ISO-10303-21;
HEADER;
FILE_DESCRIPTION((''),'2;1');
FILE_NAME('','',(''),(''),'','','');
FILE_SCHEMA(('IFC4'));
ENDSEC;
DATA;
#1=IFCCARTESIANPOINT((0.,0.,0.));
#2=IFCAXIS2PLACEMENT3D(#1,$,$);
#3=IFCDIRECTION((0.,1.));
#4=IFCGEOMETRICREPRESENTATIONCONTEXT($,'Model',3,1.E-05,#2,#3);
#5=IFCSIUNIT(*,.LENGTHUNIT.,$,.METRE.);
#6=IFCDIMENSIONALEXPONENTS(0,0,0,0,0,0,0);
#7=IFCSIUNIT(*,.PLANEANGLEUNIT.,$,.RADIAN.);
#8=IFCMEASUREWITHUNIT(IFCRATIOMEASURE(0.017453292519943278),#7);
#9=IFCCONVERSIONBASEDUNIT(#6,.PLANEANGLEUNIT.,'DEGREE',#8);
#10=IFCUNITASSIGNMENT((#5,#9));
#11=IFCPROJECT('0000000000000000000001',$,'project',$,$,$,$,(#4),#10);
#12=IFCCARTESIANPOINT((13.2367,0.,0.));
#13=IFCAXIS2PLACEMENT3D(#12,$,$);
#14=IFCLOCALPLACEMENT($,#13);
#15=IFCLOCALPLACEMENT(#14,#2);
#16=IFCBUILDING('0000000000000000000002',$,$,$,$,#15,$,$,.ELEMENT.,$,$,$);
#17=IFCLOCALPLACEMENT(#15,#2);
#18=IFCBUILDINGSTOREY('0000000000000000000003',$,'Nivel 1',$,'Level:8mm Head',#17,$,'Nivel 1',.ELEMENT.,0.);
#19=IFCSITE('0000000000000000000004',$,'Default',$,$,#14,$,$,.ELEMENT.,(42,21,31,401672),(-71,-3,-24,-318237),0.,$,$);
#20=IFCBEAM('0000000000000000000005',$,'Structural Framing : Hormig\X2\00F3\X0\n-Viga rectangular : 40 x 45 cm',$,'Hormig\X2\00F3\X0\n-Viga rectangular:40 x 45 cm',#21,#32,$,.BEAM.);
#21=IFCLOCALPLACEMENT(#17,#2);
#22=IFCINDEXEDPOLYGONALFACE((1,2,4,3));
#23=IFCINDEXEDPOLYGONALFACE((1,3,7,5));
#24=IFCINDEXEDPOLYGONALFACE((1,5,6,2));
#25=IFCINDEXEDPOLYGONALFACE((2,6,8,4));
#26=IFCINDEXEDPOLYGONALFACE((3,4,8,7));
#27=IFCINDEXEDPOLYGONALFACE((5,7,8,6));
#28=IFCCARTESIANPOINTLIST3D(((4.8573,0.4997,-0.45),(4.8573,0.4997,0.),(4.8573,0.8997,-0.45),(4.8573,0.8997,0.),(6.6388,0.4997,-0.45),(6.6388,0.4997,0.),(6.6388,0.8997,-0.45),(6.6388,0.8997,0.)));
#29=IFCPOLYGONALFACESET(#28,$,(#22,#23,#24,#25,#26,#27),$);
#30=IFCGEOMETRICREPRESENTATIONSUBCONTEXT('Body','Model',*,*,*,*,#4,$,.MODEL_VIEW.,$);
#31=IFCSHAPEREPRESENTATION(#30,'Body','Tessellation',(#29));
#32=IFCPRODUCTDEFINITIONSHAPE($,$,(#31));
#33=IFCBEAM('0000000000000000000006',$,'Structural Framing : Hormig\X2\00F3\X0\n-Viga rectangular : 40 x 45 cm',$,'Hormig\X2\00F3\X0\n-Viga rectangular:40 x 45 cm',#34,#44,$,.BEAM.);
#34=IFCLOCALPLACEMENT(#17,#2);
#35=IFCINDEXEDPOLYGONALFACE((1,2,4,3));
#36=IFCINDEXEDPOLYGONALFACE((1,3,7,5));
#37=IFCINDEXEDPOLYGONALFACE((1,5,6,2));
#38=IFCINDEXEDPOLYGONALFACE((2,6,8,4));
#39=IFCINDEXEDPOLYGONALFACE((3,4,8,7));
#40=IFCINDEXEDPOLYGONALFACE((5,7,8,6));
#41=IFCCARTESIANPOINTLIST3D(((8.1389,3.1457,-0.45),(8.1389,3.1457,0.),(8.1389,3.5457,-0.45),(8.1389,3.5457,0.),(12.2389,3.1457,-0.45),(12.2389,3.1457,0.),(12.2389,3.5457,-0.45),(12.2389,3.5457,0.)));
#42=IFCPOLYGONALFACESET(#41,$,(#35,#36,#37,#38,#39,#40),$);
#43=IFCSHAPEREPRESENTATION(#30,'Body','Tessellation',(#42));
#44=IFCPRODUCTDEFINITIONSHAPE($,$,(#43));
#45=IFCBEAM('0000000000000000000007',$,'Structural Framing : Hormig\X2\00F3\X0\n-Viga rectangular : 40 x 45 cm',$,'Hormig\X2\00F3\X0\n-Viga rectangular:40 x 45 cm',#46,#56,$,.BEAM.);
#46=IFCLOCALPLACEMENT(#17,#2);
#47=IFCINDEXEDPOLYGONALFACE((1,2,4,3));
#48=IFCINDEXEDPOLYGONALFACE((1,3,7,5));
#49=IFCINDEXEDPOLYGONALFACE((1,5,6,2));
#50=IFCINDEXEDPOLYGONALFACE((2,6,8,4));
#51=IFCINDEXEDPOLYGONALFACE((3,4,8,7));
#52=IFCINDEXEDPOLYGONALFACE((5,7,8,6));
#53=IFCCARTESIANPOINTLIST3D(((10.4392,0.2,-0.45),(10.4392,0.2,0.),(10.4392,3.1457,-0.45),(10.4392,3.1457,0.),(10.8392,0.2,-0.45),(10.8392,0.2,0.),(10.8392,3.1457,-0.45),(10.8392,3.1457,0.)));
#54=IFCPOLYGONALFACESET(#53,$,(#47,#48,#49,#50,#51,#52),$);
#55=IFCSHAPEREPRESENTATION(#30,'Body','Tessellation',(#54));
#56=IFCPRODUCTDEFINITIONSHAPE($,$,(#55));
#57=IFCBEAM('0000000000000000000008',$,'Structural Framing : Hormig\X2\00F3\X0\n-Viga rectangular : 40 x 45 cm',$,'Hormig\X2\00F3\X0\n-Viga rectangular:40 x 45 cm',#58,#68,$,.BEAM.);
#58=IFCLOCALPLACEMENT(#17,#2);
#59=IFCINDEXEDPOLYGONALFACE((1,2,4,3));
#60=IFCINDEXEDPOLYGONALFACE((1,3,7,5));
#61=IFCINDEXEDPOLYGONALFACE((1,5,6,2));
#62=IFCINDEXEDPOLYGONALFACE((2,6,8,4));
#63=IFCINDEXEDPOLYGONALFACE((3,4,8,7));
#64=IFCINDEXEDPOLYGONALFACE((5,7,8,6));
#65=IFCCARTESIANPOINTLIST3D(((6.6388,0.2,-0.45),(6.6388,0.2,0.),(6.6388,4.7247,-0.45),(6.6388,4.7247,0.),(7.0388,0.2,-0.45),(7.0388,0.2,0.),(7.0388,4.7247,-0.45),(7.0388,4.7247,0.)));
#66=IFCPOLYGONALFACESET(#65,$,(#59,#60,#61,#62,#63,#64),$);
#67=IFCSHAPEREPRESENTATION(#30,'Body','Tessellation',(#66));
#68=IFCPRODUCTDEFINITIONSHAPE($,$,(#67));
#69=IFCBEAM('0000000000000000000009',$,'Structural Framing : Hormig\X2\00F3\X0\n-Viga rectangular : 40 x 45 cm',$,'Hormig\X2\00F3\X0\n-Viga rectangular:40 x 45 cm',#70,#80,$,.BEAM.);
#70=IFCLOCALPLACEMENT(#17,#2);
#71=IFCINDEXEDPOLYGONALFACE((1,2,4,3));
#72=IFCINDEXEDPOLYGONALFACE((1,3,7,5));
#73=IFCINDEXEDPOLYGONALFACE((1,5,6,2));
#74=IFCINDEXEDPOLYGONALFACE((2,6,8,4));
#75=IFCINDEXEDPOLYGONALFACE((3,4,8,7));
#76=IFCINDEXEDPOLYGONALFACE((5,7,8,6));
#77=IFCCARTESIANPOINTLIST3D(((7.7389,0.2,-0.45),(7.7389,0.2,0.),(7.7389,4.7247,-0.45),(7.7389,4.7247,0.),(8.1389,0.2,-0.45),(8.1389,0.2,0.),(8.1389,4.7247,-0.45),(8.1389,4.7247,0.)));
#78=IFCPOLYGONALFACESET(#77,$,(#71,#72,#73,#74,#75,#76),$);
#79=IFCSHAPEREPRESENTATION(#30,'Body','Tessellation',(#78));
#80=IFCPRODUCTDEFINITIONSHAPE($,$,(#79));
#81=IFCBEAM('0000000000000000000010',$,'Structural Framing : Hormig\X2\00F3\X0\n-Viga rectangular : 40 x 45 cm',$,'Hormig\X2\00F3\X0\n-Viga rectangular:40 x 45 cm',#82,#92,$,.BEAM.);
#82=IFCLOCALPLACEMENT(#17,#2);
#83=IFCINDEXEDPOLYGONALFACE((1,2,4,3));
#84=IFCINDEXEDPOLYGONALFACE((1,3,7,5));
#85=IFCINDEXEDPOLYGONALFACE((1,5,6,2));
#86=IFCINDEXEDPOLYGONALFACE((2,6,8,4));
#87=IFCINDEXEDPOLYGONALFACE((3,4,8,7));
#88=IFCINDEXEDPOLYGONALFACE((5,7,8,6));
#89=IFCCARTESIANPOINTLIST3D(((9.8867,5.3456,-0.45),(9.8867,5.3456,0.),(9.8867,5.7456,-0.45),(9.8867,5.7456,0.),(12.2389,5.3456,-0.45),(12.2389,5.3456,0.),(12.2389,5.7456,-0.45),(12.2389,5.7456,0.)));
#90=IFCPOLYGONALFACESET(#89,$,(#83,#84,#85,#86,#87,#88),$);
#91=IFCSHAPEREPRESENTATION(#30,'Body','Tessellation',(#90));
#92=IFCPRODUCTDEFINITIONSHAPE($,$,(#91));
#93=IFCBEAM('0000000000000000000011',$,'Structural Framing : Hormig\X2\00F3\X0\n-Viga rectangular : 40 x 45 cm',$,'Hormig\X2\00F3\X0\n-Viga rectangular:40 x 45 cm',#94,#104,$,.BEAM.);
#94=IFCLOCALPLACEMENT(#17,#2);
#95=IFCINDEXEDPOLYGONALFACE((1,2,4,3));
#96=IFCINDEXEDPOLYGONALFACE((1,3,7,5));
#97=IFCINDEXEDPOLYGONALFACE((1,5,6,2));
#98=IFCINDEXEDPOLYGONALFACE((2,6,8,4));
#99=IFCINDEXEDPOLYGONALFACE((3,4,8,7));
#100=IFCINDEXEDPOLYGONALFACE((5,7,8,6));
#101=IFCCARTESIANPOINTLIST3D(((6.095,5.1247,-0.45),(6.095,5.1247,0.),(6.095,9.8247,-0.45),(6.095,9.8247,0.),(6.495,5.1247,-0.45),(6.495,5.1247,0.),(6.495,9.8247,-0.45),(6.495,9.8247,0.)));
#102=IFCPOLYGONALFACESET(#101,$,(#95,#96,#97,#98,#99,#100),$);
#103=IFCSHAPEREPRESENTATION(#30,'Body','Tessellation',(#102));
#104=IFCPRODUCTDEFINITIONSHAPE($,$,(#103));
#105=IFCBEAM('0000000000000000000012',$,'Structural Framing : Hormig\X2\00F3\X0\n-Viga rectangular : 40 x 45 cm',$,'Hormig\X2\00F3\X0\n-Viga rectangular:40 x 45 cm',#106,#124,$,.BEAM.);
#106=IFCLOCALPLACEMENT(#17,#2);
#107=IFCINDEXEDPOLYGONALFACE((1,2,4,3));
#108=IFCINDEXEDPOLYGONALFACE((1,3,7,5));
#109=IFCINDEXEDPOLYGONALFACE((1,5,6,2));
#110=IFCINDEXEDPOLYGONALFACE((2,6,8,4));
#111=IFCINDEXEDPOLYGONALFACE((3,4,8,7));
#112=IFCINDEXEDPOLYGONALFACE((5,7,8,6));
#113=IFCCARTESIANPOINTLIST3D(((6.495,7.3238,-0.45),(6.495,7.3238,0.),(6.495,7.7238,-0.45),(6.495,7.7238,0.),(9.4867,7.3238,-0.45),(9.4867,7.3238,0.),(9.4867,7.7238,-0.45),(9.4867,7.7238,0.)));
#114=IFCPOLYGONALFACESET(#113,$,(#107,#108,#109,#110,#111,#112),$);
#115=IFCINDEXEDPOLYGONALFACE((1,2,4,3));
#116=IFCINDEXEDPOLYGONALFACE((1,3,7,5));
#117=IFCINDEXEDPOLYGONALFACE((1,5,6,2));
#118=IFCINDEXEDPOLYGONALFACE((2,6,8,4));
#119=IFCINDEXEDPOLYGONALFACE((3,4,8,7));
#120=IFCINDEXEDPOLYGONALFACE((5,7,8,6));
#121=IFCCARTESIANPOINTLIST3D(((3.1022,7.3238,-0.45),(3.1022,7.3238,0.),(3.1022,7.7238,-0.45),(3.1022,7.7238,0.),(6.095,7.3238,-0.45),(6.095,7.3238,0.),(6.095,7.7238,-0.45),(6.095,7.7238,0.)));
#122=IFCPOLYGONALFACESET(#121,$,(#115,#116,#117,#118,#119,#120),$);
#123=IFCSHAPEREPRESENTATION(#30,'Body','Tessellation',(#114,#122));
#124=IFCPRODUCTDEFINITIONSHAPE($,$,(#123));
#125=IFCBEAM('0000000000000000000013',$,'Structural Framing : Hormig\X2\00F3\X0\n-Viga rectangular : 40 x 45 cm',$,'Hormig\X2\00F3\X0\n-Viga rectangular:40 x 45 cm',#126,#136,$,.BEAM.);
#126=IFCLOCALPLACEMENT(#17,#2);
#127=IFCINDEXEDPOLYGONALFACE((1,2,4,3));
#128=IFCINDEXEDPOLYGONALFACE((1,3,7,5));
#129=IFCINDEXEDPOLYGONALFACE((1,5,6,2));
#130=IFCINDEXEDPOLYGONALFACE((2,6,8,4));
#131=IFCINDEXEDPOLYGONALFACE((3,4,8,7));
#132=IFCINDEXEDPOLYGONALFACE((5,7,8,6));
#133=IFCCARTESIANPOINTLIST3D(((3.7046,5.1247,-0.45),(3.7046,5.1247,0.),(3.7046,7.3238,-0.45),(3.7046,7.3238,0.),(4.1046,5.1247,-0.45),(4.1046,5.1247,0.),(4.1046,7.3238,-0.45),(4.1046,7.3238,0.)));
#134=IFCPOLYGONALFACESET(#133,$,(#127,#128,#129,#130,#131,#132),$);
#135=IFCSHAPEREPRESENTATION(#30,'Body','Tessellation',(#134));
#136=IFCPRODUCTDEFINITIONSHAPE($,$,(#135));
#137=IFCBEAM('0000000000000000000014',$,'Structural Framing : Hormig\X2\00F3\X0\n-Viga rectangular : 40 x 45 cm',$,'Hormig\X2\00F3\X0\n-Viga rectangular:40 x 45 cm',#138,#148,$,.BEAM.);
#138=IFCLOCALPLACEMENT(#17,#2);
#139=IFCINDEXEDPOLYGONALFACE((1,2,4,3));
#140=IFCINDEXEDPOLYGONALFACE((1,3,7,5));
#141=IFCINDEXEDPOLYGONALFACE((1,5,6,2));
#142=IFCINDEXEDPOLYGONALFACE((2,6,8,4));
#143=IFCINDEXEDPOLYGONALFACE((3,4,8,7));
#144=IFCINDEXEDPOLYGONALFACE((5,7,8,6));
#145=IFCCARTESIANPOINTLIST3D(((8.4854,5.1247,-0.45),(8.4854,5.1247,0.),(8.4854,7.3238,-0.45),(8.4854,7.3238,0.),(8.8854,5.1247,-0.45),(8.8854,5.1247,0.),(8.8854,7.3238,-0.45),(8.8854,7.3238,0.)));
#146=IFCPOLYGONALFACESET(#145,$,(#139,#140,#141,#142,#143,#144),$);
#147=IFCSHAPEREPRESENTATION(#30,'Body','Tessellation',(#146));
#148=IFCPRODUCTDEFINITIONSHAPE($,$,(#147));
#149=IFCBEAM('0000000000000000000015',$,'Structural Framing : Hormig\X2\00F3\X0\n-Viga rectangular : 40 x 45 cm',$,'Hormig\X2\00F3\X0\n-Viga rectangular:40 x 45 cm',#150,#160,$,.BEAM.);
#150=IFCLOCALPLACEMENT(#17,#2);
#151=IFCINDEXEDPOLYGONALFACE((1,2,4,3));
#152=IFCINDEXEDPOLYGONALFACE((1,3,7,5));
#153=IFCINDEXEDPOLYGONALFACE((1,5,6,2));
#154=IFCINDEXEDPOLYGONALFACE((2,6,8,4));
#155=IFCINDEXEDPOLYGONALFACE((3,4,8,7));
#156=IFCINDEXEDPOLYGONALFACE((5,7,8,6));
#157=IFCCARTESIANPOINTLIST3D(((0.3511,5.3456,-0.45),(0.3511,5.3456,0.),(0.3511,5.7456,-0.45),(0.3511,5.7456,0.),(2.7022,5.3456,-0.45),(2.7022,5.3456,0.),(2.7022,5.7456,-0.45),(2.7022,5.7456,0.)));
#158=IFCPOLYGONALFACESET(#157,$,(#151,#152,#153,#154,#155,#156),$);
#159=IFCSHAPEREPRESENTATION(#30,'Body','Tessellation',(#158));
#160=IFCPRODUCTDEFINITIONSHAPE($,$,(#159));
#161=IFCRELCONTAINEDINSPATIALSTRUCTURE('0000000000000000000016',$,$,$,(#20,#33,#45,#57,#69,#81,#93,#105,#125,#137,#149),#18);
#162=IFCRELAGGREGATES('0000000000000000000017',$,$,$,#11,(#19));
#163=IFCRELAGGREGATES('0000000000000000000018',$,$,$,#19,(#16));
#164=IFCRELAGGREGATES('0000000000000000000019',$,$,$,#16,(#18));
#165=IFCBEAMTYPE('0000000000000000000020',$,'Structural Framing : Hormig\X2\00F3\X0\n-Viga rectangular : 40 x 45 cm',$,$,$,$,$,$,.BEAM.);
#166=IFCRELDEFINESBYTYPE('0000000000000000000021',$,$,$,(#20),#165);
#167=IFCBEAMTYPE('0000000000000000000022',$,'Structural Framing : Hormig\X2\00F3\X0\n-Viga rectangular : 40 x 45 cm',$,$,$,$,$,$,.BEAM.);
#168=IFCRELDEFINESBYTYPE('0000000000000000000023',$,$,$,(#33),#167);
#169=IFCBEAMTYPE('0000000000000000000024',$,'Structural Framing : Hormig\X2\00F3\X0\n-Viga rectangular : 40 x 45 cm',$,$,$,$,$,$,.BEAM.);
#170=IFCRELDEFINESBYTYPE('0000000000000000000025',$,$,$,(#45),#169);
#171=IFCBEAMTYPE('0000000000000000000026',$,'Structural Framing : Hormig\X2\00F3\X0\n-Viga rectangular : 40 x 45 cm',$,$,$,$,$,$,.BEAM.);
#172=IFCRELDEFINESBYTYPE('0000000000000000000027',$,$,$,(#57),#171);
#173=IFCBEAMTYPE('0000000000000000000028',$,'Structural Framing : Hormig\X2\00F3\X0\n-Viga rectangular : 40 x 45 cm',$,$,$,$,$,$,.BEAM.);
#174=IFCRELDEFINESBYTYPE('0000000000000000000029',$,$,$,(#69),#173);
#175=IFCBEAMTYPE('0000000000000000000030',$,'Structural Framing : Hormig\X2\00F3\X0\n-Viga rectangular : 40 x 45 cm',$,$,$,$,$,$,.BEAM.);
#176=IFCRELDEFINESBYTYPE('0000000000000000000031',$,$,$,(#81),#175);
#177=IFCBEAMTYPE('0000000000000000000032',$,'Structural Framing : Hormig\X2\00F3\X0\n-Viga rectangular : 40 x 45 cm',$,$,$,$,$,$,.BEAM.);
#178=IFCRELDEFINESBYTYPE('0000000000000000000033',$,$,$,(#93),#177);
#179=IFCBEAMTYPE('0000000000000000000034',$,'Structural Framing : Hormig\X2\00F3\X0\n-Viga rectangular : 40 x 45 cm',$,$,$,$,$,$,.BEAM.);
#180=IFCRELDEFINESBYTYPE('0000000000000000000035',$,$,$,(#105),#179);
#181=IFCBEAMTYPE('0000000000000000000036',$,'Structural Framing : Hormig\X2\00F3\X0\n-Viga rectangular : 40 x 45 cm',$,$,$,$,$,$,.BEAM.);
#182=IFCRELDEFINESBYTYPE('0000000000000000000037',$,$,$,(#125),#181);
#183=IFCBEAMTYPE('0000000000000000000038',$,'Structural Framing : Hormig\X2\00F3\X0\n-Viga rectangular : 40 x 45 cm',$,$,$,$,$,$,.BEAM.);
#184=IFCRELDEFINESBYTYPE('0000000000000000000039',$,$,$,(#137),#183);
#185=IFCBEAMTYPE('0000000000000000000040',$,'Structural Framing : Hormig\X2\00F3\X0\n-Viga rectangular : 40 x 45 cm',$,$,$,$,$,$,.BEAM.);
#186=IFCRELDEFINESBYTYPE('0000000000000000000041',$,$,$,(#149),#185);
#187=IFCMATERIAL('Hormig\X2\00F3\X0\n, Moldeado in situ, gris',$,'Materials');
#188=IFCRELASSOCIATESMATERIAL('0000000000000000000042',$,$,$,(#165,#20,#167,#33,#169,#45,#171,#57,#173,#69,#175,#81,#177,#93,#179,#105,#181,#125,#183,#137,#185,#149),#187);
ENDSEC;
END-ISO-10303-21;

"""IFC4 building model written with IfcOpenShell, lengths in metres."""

from ifc_helpers import new_model, entity, si_unit, converted_unit, direction, frame, origin, place, context, subcontext, project, spatial, indexed_curve, outline, extrude, source, transform, mapped, material, type_object, type_shapes, element, save


model = new_model("IFC4")

# Units and contexts
model_context = context("Model", 3, precision=1e-05, world=origin(), true_north=direction((0.0, 1.0)))
body_context = subcontext(model_context, "Body", "Model", "MODEL_VIEW")
ifc_project = project(units=[si_unit("LENGTHUNIT", "METRE"), converted_unit("PLANEANGLEUNIT", "DEGREE", entity("IfcRatioMeasure", 0.017453292519943278), si_unit("PLANEANGLEUNIT", "RADIAN"), dimensions=[0, 0, 0, 0, 0, 0, 0])], contexts=[model_context])

# Site, building, storey
site_placement = place(None, frame((13.2367, 0.0, 0.0)))
site = spatial("IfcSite", under=ifc_project, at=site_placement, Name="Default", CompositionType="ELEMENT", RefLatitude=(42, 21, 31, 401672), RefLongitude=(-71, -3, -24, -318237), RefElevation=0.0)
building_placement = place(site_placement, origin())
building = spatial("IfcBuilding", under=site, at=building_placement, CompositionType="ELEMENT")
storey_placement = place(building_placement, origin())
storey = spatial("IfcBuildingStorey", under=building, at=storey_placement, Name="Nivel 1", ObjectType="Level:8mm Head", LongName="Nivel 1", CompositionType="ELEMENT", Elevation=0.0)

# Beams
ifc_material_1 = material(Name="Hormigón, Moldeado in situ, gris", Category="Materials")
beam_type_1 = type_object("IfcBeamType", Name="Structural Framing : Hormigón-Viga rectangular : 40 x 45 cm", PredefinedType="BEAM", material=ifc_material_1)
shared_shape_1 = source(origin(), body_context, "Body", "SweptSolid", [
    extrude(outline(indexed_curve([(-0.225, -0.2), (0.225, -0.2), (0.225, 0.2), (-0.225, 0.2), (-0.225, -0.2)], self_intersect=False)), frame((4.8573, 0.6997, -0.225), z_axis=(1.0, 0.0, 0.0), x_axis=(0.0, 0.0, -1.0)), (0.0, 0.0, 1.0), 1.7816),
])
type_shapes(beam_type_1, [shared_shape_1])
beam_1_placement = place(storey_placement, origin())
element("IfcBeam", 1, at=beam_1_placement, inside=storey, type_object=beam_type_1, material=ifc_material_1, Name="Structural Framing : Hormigón-Viga rectangular : 40 x 45 cm", ObjectType="Hormigón-Viga rectangular:40 x 45 cm", PredefinedType="BEAM", context=body_context, shape_type="MappedRepresentation", body=[
    mapped(shared_shape_1, transform((0.0, 0.0, 0.0), scale=1.0)),
])
beam_type_2 = type_object("IfcBeamType", Name="Structural Framing : Hormigón-Viga rectangular : 40 x 45 cm", PredefinedType="BEAM", material=ifc_material_1)
shared_shape_2 = source(origin(), body_context, "Body", "SweptSolid", [
    extrude(outline(indexed_curve([(-0.225, -0.2), (0.225, -0.2), (0.225, 0.2), (-0.225, 0.2), (-0.225, -0.2)], self_intersect=False)), frame((8.1389, 3.3457, -0.225), z_axis=(1.0, 0.0, 0.0), x_axis=(0.0, 0.0, -1.0)), (0.0, 0.0, 1.0), 4.1),
])
type_shapes(beam_type_2, [shared_shape_2])
beam_2_placement = place(storey_placement, origin())
element("IfcBeam", 2, at=beam_2_placement, inside=storey, type_object=beam_type_2, material=ifc_material_1, Name="Structural Framing : Hormigón-Viga rectangular : 40 x 45 cm", ObjectType="Hormigón-Viga rectangular:40 x 45 cm", PredefinedType="BEAM", context=body_context, shape_type="MappedRepresentation", body=[
    mapped(shared_shape_2, transform((0.0, 0.0, 0.0), scale=1.0)),
])
beam_type_3 = type_object("IfcBeamType", Name="Structural Framing : Hormigón-Viga rectangular : 40 x 45 cm", PredefinedType="BEAM", material=ifc_material_1)
shared_shape_3 = source(origin(), body_context, "Body", "SweptSolid", [
    extrude(outline(indexed_curve([(-0.2, -0.225), (0.2, -0.225), (0.2, 0.225), (-0.2, 0.225), (-0.2, -0.225)], self_intersect=False)), frame((10.6392, 3.1457, -0.225), z_axis=(0.0, -1.0, 0.0), x_axis=(-1.0, 0.0, 0.0)), (0.0, 0.0, 1.0), 2.9457),
])
type_shapes(beam_type_3, [shared_shape_3])
beam_3_placement = place(storey_placement, origin())
element("IfcBeam", 3, at=beam_3_placement, inside=storey, type_object=beam_type_3, material=ifc_material_1, Name="Structural Framing : Hormigón-Viga rectangular : 40 x 45 cm", ObjectType="Hormigón-Viga rectangular:40 x 45 cm", PredefinedType="BEAM", context=body_context, shape_type="MappedRepresentation", body=[
    mapped(shared_shape_3, transform((0.0, 0.0, 0.0), scale=1.0)),
])
beam_type_4 = type_object("IfcBeamType", Name="Structural Framing : Hormigón-Viga rectangular : 40 x 45 cm", PredefinedType="BEAM", material=ifc_material_1)
shared_shape_4 = source(origin(), body_context, "Body", "SweptSolid", [
    extrude(outline(indexed_curve([(-0.2, -0.225), (0.2, -0.225), (0.2, 0.225), (-0.2, 0.225), (-0.2, -0.225)], self_intersect=False)), frame((6.8388, 4.7247, -0.225), z_axis=(0.0, -1.0, 0.0), x_axis=(-1.0, 0.0, 0.0)), (0.0, 0.0, 1.0), 4.5247),
])
type_shapes(beam_type_4, [shared_shape_4])
beam_4_placement = place(storey_placement, origin())
element("IfcBeam", 4, at=beam_4_placement, inside=storey, type_object=beam_type_4, material=ifc_material_1, Name="Structural Framing : Hormigón-Viga rectangular : 40 x 45 cm", ObjectType="Hormigón-Viga rectangular:40 x 45 cm", PredefinedType="BEAM", context=body_context, shape_type="MappedRepresentation", body=[
    mapped(shared_shape_4, transform((0.0, 0.0, 0.0), scale=1.0)),
])
beam_type_5 = type_object("IfcBeamType", Name="Structural Framing : Hormigón-Viga rectangular : 40 x 45 cm", PredefinedType="BEAM", material=ifc_material_1)
shared_shape_5 = source(origin(), body_context, "Body", "SweptSolid", [
    extrude(outline(indexed_curve([(-0.2, -0.225), (0.2, -0.225), (0.2, 0.225), (-0.2, 0.225), (-0.2, -0.225)], self_intersect=False)), frame((7.9389, 4.7247, -0.225), z_axis=(0.0, -1.0, 0.0), x_axis=(-1.0, 0.0, 0.0)), (0.0, 0.0, 1.0), 4.5247),
])
type_shapes(beam_type_5, [shared_shape_5])
beam_5_placement = place(storey_placement, origin())
element("IfcBeam", 5, at=beam_5_placement, inside=storey, type_object=beam_type_5, material=ifc_material_1, Name="Structural Framing : Hormigón-Viga rectangular : 40 x 45 cm", ObjectType="Hormigón-Viga rectangular:40 x 45 cm", PredefinedType="BEAM", context=body_context, shape_type="MappedRepresentation", body=[
    mapped(shared_shape_5, transform((0.0, 0.0, 0.0), scale=1.0)),
])
beam_type_6 = type_object("IfcBeamType", Name="Structural Framing : Hormigón-Viga rectangular : 40 x 45 cm", PredefinedType="BEAM", material=ifc_material_1)
shared_shape_6 = source(origin(), body_context, "Body", "SweptSolid", [
    extrude(outline(indexed_curve([(-0.225, -0.2), (0.225, -0.2), (0.225, 0.2), (-0.225, 0.2), (-0.225, -0.2)], self_intersect=False)), frame((9.8867, 5.5456, -0.225), z_axis=(1.0, 0.0, 0.0), x_axis=(0.0, 0.0, -1.0)), (0.0, 0.0, 1.0), 2.3522),
])
type_shapes(beam_type_6, [shared_shape_6])
beam_6_placement = place(storey_placement, origin())
element("IfcBeam", 6, at=beam_6_placement, inside=storey, type_object=beam_type_6, material=ifc_material_1, Name="Structural Framing : Hormigón-Viga rectangular : 40 x 45 cm", ObjectType="Hormigón-Viga rectangular:40 x 45 cm", PredefinedType="BEAM", context=body_context, shape_type="MappedRepresentation", body=[
    mapped(shared_shape_6, transform((0.0, 0.0, 0.0), scale=1.0)),
])
beam_type_7 = type_object("IfcBeamType", Name="Structural Framing : Hormigón-Viga rectangular : 40 x 45 cm", PredefinedType="BEAM", material=ifc_material_1)
shared_shape_7 = source(origin(), body_context, "Body", "SweptSolid", [
    extrude(outline(indexed_curve([(-0.2, -0.225), (0.2, -0.225), (0.2, 0.225), (-0.2, 0.225), (-0.2, -0.225)], self_intersect=False)), frame((6.295, 9.8247, -0.225), z_axis=(0.0, -1.0, 0.0), x_axis=(-1.0, 0.0, 0.0)), (0.0, 0.0, 1.0), 4.7001),
])
type_shapes(beam_type_7, [shared_shape_7])
beam_7_placement = place(storey_placement, origin())
element("IfcBeam", 7, at=beam_7_placement, inside=storey, type_object=beam_type_7, material=ifc_material_1, Name="Structural Framing : Hormigón-Viga rectangular : 40 x 45 cm", ObjectType="Hormigón-Viga rectangular:40 x 45 cm", PredefinedType="BEAM", context=body_context, shape_type="MappedRepresentation", body=[
    mapped(shared_shape_7, transform((0.0, 0.0, 0.0), scale=1.0)),
])
beam_type_8 = type_object("IfcBeamType", Name="Structural Framing : Hormigón-Viga rectangular : 40 x 45 cm", PredefinedType="BEAM", material=ifc_material_1)
shared_shape_8 = source(origin(), body_context, "Body", "SweptSolid", [
    extrude(outline(indexed_curve([(-0.225, -0.2), (0.225, -0.2), (0.225, 0.2), (-0.225, 0.2), (-0.225, -0.2)], self_intersect=False)), frame((6.495, 7.5238, -0.225), z_axis=(1.0, 0.0, 0.0), x_axis=(0.0, 0.0, -1.0)), (0.0, 0.0, 1.0), 2.9917),
    extrude(outline(indexed_curve([(-0.225, -0.2), (0.225, -0.2), (0.225, 0.2), (-0.225, 0.2), (-0.225, -0.2)], self_intersect=False)), frame((3.1022, 7.5238, -0.225), z_axis=(1.0, 0.0, 0.0), x_axis=(0.0, 0.0, -1.0)), (0.0, 0.0, 1.0), 2.9928),
])
type_shapes(beam_type_8, [shared_shape_8])
beam_8_placement = place(storey_placement, origin())
element("IfcBeam", 8, at=beam_8_placement, inside=storey, type_object=beam_type_8, material=ifc_material_1, Name="Structural Framing : Hormigón-Viga rectangular : 40 x 45 cm", ObjectType="Hormigón-Viga rectangular:40 x 45 cm", PredefinedType="BEAM", context=body_context, shape_type="MappedRepresentation", body=[
    mapped(shared_shape_8, transform((0.0, 0.0, 0.0), scale=1.0)),
])
beam_type_9 = type_object("IfcBeamType", Name="Structural Framing : Hormigón-Viga rectangular : 40 x 45 cm", PredefinedType="BEAM", material=ifc_material_1)
shared_shape_9 = source(origin(), body_context, "Body", "SweptSolid", [
    extrude(outline(indexed_curve([(-0.2, -0.225), (0.2, -0.225), (0.2, 0.225), (-0.2, 0.225), (-0.2, -0.225)], self_intersect=False)), frame((3.9046, 7.3238, -0.225), z_axis=(0.0, -1.0, 0.0), x_axis=(-1.0, 0.0, 0.0)), (0.0, 0.0, 1.0), 2.1991),
])
type_shapes(beam_type_9, [shared_shape_9])
beam_9_placement = place(storey_placement, origin())
element("IfcBeam", 9, at=beam_9_placement, inside=storey, type_object=beam_type_9, material=ifc_material_1, Name="Structural Framing : Hormigón-Viga rectangular : 40 x 45 cm", ObjectType="Hormigón-Viga rectangular:40 x 45 cm", PredefinedType="BEAM", context=body_context, shape_type="MappedRepresentation", body=[
    mapped(shared_shape_9, transform((0.0, 0.0, 0.0), scale=1.0)),
])
beam_type_10 = type_object("IfcBeamType", Name="Structural Framing : Hormigón-Viga rectangular : 40 x 45 cm", PredefinedType="BEAM", material=ifc_material_1)
shared_shape_10 = source(origin(), body_context, "Body", "SweptSolid", [
    extrude(outline(indexed_curve([(-0.2, -0.225), (0.2, -0.225), (0.2, 0.225), (-0.2, 0.225), (-0.2, -0.225)], self_intersect=False)), frame((8.6854, 7.3238, -0.225), z_axis=(0.0, -1.0, 0.0), x_axis=(-1.0, 0.0, 0.0)), (0.0, 0.0, 1.0), 2.1991),
])
type_shapes(beam_type_10, [shared_shape_10])
beam_10_placement = place(storey_placement, origin())
element("IfcBeam", 10, at=beam_10_placement, inside=storey, type_object=beam_type_10, material=ifc_material_1, Name="Structural Framing : Hormigón-Viga rectangular : 40 x 45 cm", ObjectType="Hormigón-Viga rectangular:40 x 45 cm", PredefinedType="BEAM", context=body_context, shape_type="MappedRepresentation", body=[
    mapped(shared_shape_10, transform((0.0, 0.0, 0.0), scale=1.0)),
])
beam_type_11 = type_object("IfcBeamType", Name="Structural Framing : Hormigón-Viga rectangular : 40 x 45 cm", PredefinedType="BEAM", material=ifc_material_1)
shared_shape_11 = source(origin(), body_context, "Body", "SweptSolid", [
    extrude(outline(indexed_curve([(-0.225, -0.2), (0.225, -0.2), (0.225, 0.2), (-0.225, 0.2), (-0.225, -0.2)], self_intersect=False)), frame((0.3511, 5.5456, -0.225), z_axis=(1.0, 0.0, 0.0), x_axis=(0.0, 0.0, -1.0)), (0.0, 0.0, 1.0), 2.351),
])
type_shapes(beam_type_11, [shared_shape_11])
beam_11_placement = place(storey_placement, origin())
element("IfcBeam", 11, at=beam_11_placement, inside=storey, type_object=beam_type_11, material=ifc_material_1, Name="Structural Framing : Hormigón-Viga rectangular : 40 x 45 cm", ObjectType="Hormigón-Viga rectangular:40 x 45 cm", PredefinedType="BEAM", context=body_context, shape_type="MappedRepresentation", body=[
    mapped(shared_shape_11, transform((0.0, 0.0, 0.0), scale=1.0)),
])

save(model, "model.ifc")
